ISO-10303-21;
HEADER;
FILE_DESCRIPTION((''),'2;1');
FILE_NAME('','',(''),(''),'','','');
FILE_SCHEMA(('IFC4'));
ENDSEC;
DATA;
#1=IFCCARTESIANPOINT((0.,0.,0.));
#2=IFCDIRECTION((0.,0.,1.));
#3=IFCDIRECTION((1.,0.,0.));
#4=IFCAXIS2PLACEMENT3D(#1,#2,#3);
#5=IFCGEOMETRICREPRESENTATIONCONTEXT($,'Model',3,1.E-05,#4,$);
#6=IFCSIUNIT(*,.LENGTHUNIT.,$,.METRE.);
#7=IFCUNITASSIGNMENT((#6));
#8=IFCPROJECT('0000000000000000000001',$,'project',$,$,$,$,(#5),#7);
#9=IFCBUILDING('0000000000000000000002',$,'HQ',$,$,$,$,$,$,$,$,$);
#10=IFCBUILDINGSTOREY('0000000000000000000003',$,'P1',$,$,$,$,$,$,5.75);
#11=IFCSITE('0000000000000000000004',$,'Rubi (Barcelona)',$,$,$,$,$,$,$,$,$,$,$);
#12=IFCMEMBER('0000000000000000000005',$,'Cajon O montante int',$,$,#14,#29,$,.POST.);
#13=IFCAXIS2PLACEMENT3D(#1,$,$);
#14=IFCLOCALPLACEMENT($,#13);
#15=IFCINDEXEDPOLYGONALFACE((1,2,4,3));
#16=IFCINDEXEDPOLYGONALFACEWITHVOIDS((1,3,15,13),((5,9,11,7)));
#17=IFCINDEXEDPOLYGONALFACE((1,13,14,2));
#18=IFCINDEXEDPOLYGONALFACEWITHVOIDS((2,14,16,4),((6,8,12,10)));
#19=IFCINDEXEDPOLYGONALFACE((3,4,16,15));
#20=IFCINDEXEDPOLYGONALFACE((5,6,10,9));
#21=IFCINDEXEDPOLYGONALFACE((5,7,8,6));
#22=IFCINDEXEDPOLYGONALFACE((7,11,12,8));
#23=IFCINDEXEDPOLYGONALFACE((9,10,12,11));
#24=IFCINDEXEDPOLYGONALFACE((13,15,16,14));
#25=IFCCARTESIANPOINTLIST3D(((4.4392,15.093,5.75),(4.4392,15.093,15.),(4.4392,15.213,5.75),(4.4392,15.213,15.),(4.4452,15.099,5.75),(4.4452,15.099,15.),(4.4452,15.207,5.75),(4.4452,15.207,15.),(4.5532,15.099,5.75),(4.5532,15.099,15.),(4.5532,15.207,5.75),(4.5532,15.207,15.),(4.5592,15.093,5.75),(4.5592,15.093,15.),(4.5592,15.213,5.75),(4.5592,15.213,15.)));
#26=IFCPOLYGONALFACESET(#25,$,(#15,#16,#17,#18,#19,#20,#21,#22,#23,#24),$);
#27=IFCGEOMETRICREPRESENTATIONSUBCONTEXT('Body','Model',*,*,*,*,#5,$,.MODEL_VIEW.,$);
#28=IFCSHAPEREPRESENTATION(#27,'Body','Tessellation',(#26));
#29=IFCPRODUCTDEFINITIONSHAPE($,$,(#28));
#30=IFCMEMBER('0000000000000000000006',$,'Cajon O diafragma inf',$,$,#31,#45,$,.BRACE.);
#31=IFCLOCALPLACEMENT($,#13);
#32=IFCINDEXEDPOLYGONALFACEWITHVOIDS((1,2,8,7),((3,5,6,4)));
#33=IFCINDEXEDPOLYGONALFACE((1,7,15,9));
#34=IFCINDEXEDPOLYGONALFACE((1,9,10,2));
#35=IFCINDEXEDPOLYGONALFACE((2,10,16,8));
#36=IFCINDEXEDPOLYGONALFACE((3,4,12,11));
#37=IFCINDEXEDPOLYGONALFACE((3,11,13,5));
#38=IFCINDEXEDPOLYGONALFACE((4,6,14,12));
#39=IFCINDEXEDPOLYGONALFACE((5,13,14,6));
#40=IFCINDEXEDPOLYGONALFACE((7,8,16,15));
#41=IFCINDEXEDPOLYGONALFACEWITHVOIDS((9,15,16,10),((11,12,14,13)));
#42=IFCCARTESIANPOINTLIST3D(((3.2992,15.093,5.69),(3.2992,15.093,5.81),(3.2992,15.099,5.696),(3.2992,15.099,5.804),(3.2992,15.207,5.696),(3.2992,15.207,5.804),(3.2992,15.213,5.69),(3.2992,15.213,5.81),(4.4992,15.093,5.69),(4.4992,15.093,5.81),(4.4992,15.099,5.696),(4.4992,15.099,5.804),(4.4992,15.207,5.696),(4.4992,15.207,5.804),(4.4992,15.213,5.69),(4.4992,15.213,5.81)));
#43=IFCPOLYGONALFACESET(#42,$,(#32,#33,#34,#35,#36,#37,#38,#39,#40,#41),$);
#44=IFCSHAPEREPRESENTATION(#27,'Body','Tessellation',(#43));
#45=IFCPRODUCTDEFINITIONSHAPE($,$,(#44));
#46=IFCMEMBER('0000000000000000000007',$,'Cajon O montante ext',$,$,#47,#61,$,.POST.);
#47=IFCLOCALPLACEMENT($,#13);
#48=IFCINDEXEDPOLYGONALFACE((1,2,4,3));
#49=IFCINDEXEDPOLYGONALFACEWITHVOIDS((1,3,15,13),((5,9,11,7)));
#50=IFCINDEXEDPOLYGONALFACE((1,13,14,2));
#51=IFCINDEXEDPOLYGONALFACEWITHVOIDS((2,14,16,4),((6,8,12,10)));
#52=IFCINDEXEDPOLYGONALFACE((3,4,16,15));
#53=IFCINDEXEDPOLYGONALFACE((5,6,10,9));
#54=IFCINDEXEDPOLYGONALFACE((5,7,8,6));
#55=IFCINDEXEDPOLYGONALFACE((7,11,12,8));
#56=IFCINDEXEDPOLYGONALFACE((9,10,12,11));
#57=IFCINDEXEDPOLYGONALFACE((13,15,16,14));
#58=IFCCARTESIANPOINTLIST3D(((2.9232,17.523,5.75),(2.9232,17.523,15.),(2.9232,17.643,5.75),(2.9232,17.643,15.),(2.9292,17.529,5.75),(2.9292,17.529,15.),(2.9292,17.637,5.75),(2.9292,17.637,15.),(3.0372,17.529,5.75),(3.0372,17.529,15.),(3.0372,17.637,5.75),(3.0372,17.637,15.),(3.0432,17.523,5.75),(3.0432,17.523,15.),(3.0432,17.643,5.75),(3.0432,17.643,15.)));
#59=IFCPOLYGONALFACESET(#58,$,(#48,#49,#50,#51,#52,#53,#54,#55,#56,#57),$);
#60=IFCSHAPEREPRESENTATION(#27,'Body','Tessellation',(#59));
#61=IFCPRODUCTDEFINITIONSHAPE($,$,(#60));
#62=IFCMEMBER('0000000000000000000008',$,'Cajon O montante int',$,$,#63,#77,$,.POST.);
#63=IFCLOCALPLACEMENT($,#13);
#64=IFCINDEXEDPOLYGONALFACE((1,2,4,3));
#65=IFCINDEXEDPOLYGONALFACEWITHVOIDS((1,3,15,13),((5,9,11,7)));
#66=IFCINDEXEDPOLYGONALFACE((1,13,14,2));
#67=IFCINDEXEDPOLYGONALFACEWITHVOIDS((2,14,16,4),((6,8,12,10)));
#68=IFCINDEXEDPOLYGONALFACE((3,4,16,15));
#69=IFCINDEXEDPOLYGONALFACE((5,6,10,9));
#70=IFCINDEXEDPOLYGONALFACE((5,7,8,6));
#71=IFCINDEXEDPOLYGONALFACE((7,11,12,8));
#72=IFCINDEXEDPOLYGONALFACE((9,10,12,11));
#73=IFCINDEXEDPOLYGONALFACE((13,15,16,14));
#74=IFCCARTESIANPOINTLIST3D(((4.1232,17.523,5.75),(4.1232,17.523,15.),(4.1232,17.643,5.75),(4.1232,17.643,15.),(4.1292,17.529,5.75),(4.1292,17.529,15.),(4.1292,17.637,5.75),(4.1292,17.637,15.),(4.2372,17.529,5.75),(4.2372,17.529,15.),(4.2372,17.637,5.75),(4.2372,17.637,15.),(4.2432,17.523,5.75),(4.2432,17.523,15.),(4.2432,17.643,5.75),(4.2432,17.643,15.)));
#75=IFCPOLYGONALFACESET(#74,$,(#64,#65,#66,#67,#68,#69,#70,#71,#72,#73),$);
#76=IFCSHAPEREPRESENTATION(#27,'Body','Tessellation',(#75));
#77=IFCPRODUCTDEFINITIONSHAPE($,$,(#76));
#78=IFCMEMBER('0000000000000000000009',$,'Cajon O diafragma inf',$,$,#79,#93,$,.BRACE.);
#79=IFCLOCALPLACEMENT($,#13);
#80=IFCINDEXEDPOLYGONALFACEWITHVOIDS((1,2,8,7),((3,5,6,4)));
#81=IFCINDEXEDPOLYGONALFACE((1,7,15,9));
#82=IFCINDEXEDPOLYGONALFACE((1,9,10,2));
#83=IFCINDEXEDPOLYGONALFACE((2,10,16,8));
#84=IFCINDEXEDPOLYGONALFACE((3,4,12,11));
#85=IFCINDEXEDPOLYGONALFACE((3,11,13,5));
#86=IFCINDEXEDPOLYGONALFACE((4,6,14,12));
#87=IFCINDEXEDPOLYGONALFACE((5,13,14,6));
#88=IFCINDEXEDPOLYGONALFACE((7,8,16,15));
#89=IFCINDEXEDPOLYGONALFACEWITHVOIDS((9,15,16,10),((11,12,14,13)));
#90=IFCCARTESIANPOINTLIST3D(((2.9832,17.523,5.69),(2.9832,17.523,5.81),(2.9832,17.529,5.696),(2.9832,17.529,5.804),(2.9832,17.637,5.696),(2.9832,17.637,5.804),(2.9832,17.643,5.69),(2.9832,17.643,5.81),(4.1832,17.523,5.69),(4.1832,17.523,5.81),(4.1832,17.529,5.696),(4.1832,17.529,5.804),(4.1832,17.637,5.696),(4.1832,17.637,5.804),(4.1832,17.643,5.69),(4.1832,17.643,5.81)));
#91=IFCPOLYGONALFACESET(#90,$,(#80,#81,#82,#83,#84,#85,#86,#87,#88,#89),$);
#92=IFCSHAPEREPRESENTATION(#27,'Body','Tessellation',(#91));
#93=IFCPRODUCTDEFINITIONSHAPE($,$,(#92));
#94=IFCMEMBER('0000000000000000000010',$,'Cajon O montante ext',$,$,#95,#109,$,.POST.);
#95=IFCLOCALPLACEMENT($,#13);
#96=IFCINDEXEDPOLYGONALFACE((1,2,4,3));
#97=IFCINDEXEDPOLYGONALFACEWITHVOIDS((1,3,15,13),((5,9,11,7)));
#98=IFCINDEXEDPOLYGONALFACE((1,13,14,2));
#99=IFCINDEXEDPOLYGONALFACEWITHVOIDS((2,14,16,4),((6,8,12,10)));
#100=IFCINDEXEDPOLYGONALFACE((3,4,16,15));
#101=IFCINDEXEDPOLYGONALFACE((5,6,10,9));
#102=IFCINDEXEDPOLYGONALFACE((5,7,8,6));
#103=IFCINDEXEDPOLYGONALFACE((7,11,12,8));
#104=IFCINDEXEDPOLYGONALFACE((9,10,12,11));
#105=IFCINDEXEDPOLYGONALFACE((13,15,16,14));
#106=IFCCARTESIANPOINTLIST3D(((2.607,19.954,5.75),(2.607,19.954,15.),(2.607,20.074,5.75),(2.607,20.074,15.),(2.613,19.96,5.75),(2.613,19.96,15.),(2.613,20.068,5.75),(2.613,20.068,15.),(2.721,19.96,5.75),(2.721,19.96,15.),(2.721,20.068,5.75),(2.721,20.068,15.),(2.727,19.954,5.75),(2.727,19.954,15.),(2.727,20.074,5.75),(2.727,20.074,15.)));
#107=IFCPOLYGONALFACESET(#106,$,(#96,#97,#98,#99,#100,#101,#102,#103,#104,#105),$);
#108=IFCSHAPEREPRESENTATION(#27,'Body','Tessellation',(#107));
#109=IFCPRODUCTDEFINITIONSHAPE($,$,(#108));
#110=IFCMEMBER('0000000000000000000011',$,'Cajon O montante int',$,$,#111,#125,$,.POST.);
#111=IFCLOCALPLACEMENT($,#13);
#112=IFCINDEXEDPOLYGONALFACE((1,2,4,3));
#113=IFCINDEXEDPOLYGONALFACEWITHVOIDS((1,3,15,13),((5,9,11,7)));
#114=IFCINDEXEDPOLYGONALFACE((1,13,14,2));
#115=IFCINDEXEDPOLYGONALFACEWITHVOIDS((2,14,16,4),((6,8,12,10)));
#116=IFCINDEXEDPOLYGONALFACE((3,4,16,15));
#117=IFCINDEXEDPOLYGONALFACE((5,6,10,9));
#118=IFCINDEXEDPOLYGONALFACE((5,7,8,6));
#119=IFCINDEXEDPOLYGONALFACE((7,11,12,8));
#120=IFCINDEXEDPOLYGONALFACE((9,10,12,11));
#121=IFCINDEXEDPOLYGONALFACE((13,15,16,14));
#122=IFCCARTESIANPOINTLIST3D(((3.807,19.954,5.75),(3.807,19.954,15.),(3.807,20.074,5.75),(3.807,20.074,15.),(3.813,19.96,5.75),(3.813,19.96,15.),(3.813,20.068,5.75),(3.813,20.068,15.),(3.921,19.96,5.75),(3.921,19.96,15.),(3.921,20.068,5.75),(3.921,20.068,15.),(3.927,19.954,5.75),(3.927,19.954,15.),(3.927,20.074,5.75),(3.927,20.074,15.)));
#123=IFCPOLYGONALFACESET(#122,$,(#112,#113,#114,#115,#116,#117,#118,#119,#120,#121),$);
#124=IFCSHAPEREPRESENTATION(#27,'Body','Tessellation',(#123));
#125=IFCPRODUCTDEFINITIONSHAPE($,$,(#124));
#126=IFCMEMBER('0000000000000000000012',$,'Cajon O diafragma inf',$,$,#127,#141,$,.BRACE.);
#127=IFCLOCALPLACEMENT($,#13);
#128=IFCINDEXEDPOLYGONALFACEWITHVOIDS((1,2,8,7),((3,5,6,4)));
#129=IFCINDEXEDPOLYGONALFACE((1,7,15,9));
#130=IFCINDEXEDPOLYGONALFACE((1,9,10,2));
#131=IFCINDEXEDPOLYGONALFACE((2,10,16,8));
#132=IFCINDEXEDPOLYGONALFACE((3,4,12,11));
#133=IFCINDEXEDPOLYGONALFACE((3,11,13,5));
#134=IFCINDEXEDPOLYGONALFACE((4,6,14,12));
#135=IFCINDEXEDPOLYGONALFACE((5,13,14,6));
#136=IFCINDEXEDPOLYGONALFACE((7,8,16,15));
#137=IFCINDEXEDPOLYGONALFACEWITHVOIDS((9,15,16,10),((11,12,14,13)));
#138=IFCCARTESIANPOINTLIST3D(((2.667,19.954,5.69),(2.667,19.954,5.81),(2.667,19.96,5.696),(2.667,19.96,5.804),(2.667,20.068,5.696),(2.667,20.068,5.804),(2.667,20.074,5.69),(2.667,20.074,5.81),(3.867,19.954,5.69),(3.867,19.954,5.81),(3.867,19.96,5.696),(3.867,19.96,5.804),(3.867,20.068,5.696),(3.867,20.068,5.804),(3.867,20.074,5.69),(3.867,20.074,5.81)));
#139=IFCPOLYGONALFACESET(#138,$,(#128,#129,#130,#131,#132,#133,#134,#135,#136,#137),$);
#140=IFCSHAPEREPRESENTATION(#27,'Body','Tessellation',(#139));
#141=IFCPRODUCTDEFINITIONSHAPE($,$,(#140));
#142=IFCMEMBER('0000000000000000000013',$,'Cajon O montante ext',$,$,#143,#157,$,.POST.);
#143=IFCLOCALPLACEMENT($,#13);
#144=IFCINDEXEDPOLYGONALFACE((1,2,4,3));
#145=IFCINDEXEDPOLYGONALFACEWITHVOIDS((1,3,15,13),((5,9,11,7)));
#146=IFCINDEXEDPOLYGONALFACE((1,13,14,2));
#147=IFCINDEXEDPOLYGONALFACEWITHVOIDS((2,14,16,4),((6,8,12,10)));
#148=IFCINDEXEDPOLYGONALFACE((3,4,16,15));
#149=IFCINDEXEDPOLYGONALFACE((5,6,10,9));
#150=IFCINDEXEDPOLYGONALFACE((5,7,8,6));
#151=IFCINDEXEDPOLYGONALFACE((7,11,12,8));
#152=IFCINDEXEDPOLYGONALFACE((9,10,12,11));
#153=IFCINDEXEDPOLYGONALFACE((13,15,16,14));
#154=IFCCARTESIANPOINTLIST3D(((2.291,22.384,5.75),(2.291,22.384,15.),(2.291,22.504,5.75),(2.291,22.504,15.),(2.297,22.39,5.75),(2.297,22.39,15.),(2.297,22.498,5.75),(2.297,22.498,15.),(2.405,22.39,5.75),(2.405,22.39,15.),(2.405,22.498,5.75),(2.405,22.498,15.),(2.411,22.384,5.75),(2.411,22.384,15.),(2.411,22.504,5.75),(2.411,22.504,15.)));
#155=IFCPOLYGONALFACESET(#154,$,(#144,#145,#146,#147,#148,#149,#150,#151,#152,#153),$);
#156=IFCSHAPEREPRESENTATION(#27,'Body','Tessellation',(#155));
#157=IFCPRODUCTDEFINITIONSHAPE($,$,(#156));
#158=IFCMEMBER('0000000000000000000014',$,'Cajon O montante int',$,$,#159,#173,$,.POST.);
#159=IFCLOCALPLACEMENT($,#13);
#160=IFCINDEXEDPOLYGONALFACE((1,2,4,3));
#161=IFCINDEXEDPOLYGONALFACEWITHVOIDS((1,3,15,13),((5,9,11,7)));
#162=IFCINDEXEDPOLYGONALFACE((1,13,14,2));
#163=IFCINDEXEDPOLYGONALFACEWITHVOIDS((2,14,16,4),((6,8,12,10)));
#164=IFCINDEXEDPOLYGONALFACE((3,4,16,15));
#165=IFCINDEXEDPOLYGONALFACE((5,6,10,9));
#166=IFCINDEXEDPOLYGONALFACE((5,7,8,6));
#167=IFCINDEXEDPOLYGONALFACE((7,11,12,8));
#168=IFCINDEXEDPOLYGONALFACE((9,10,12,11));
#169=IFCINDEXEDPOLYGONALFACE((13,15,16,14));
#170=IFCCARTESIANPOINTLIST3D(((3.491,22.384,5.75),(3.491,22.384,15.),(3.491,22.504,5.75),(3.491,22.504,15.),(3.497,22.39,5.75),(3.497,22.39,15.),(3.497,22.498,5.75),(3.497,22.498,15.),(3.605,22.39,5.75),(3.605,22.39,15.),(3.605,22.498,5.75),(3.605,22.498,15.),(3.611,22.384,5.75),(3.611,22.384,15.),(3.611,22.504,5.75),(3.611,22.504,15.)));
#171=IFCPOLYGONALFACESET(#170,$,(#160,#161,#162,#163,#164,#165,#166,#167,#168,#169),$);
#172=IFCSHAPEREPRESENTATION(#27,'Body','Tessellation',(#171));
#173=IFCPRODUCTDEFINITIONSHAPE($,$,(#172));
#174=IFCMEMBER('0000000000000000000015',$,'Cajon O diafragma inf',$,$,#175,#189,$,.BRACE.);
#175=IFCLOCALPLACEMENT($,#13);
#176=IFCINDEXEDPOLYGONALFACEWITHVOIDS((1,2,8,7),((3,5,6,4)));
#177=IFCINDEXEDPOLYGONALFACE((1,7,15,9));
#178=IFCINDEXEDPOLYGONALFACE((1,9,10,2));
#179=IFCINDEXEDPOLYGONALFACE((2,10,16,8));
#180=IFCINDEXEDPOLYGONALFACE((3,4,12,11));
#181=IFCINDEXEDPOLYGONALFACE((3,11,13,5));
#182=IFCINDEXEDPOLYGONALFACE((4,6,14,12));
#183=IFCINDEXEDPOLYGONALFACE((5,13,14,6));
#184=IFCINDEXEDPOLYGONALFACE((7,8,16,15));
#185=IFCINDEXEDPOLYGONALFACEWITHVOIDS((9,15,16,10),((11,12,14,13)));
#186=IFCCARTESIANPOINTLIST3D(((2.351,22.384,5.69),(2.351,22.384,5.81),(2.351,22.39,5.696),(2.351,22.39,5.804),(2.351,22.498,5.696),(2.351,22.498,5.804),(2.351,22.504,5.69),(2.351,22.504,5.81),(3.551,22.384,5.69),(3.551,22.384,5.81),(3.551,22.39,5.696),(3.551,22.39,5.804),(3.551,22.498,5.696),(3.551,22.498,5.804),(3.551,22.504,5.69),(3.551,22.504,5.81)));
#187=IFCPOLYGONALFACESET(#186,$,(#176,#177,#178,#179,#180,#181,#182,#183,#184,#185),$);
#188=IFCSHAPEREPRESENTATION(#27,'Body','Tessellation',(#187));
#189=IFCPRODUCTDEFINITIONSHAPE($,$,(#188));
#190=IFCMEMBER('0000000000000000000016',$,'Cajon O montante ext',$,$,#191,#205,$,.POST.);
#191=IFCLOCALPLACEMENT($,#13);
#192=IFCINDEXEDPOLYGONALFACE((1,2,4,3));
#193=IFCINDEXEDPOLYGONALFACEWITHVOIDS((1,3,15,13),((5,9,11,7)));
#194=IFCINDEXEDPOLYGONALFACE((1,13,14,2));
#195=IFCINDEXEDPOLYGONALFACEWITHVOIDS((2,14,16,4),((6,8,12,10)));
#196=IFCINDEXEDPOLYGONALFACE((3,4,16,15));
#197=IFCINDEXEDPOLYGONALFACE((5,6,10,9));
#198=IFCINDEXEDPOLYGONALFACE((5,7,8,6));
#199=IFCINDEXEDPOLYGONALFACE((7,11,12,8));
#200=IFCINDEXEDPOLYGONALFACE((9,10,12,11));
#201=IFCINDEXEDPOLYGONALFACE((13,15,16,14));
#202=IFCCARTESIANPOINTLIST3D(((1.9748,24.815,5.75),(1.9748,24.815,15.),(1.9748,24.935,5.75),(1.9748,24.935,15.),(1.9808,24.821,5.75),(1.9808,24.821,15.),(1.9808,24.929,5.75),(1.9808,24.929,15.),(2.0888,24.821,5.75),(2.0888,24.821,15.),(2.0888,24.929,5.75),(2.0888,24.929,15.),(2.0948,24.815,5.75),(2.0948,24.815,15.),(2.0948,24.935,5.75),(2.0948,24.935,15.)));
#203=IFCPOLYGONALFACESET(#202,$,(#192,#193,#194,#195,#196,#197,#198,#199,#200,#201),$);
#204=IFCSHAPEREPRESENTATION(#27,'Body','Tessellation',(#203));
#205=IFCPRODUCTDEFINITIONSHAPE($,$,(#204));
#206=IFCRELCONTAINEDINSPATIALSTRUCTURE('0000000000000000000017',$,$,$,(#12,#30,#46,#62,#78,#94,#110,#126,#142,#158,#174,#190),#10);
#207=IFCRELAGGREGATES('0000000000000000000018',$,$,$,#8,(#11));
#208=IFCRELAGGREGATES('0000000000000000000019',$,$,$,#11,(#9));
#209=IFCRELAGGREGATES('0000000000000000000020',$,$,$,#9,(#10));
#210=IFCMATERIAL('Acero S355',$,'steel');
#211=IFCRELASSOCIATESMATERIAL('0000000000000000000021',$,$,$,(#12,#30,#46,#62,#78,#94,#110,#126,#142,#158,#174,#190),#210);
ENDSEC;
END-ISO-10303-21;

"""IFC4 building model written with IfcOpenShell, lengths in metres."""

from ifc_helpers import new_model, si_unit, frame, origin_with_axes, place, context, subcontext, project, spatial, hollow_rectangle, extrude, material, element, save


model = new_model("IFC4")

# Units and contexts
model_context = context("Model", 3, precision=1e-05, world=origin_with_axes())
body_context = subcontext(model_context, "Body", "Model", "MODEL_VIEW")
ifc_project = project(units=[si_unit("LENGTHUNIT", "METRE")], contexts=[model_context])

# Site, building, storey
site = spatial("IfcSite", under=ifc_project, Name="Rubi (Barcelona)")
building = spatial("IfcBuilding", under=site, Name="HQ")
storey = spatial("IfcBuildingStorey", under=building, Name="P1", Elevation=5.75)

# Members
ifc_material = material(Name="Acero S355", Category="steel")
member_1_placement = place(None, origin_with_axes())
element("IfcMember", 1, at=member_1_placement, inside=storey, material=ifc_material, Name="Cajon O montante int", PredefinedType="POST", context=body_context, shape_type="SweptSolid", body=[
    extrude(hollow_rectangle(XDim=0.12, YDim=0.12, WallThickness=0.006), frame((4.4992, 15.153, 5.75), z_axis=(0.0, 0.0, 1.0), x_axis=(1.0, 0.0, 0.0)), (0.0, 0.0, 1.0), 9.25),
])
member_2_placement = place(None, origin_with_axes())
element("IfcMember", 2, at=member_2_placement, inside=storey, material=ifc_material, Name="Cajon O diafragma inf", PredefinedType="BRACE", context=body_context, shape_type="SweptSolid", body=[
    extrude(hollow_rectangle(XDim=0.12, YDim=0.12, WallThickness=0.006), frame((3.2992, 15.153, 5.75), z_axis=(1.0, 0.0, 0.0), x_axis=(0.0, 1.0, 0.0)), (0.0, 0.0, 1.0), 1.2),
])
member_3_placement = place(None, origin_with_axes())
element("IfcMember", 3, at=member_3_placement, inside=storey, material=ifc_material, Name="Cajon O montante ext", PredefinedType="POST", context=body_context, shape_type="SweptSolid", body=[
    extrude(hollow_rectangle(XDim=0.12, YDim=0.12, WallThickness=0.006), frame((2.9832, 17.583, 5.75), z_axis=(0.0, 0.0, 1.0), x_axis=(1.0, 0.0, 0.0)), (0.0, 0.0, 1.0), 9.25),
])
member_4_placement = place(None, origin_with_axes())
element("IfcMember", 4, at=member_4_placement, inside=storey, material=ifc_material, Name="Cajon O montante int", PredefinedType="POST", context=body_context, shape_type="SweptSolid", body=[
    extrude(hollow_rectangle(XDim=0.12, YDim=0.12, WallThickness=0.006), frame((4.1832, 17.583, 5.75), z_axis=(0.0, 0.0, 1.0), x_axis=(1.0, 0.0, 0.0)), (0.0, 0.0, 1.0), 9.25),
])
member_5_placement = place(None, origin_with_axes())
element("IfcMember", 5, at=member_5_placement, inside=storey, material=ifc_material, Name="Cajon O diafragma inf", PredefinedType="BRACE", context=body_context, shape_type="SweptSolid", body=[
    extrude(hollow_rectangle(XDim=0.12, YDim=0.12, WallThickness=0.006), frame((2.9832, 17.583, 5.75), z_axis=(1.0, 0.0, 0.0), x_axis=(0.0, 1.0, 0.0)), (0.0, 0.0, 1.0), 1.2),
])
member_6_placement = place(None, origin_with_axes())
element("IfcMember", 6, at=member_6_placement, inside=storey, material=ifc_material, Name="Cajon O montante ext", PredefinedType="POST", context=body_context, shape_type="SweptSolid", body=[
    extrude(hollow_rectangle(XDim=0.12, YDim=0.12, WallThickness=0.006), frame((2.667, 20.014, 5.75), z_axis=(0.0, 0.0, 1.0), x_axis=(1.0, 0.0, 0.0)), (0.0, 0.0, 1.0), 9.25),
])
member_7_placement = place(None, origin_with_axes())
element("IfcMember", 7, at=member_7_placement, inside=storey, material=ifc_material, Name="Cajon O montante int", PredefinedType="POST", context=body_context, shape_type="SweptSolid", body=[
    extrude(hollow_rectangle(XDim=0.12, YDim=0.12, WallThickness=0.006), frame((3.867, 20.014, 5.75), z_axis=(0.0, 0.0, 1.0), x_axis=(1.0, 0.0, 0.0)), (0.0, 0.0, 1.0), 9.25),
])
member_8_placement = place(None, origin_with_axes())
element("IfcMember", 8, at=member_8_placement, inside=storey, material=ifc_material, Name="Cajon O diafragma inf", PredefinedType="BRACE", context=body_context, shape_type="SweptSolid", body=[
    extrude(hollow_rectangle(XDim=0.12, YDim=0.12, WallThickness=0.006), frame((2.667, 20.014, 5.75), z_axis=(1.0, 0.0, 0.0), x_axis=(0.0, 1.0, 0.0)), (0.0, 0.0, 1.0), 1.2),
])
member_9_placement = place(None, origin_with_axes())
element("IfcMember", 9, at=member_9_placement, inside=storey, material=ifc_material, Name="Cajon O montante ext", PredefinedType="POST", context=body_context, shape_type="SweptSolid", body=[
    extrude(hollow_rectangle(XDim=0.12, YDim=0.12, WallThickness=0.006), frame((2.351, 22.444, 5.75), z_axis=(0.0, 0.0, 1.0), x_axis=(1.0, 0.0, 0.0)), (0.0, 0.0, 1.0), 9.25),
])
member_10_placement = place(None, origin_with_axes())
element("IfcMember", 10, at=member_10_placement, inside=storey, material=ifc_material, Name="Cajon O montante int", PredefinedType="POST", context=body_context, shape_type="SweptSolid", body=[
    extrude(hollow_rectangle(XDim=0.12, YDim=0.12, WallThickness=0.006), frame((3.551, 22.444, 5.75), z_axis=(0.0, 0.0, 1.0), x_axis=(1.0, 0.0, 0.0)), (0.0, 0.0, 1.0), 9.25),
])
member_11_placement = place(None, origin_with_axes())
element("IfcMember", 11, at=member_11_placement, inside=storey, material=ifc_material, Name="Cajon O diafragma inf", PredefinedType="BRACE", context=body_context, shape_type="SweptSolid", body=[
    extrude(hollow_rectangle(XDim=0.12, YDim=0.12, WallThickness=0.006), frame((2.351, 22.444, 5.75), z_axis=(1.0, 0.0, 0.0), x_axis=(0.0, 1.0, 0.0)), (0.0, 0.0, 1.0), 1.2),
])
member_12_placement = place(None, origin_with_axes())
element("IfcMember", 12, at=member_12_placement, inside=storey, material=ifc_material, Name="Cajon O montante ext", PredefinedType="POST", context=body_context, shape_type="SweptSolid", body=[
    extrude(hollow_rectangle(XDim=0.12, YDim=0.12, WallThickness=0.006), frame((2.0348, 24.875, 5.75), z_axis=(0.0, 0.0, 1.0), x_axis=(1.0, 0.0, 0.0)), (0.0, 0.0, 1.0), 9.25),
])

save(model, "model.ifc")
